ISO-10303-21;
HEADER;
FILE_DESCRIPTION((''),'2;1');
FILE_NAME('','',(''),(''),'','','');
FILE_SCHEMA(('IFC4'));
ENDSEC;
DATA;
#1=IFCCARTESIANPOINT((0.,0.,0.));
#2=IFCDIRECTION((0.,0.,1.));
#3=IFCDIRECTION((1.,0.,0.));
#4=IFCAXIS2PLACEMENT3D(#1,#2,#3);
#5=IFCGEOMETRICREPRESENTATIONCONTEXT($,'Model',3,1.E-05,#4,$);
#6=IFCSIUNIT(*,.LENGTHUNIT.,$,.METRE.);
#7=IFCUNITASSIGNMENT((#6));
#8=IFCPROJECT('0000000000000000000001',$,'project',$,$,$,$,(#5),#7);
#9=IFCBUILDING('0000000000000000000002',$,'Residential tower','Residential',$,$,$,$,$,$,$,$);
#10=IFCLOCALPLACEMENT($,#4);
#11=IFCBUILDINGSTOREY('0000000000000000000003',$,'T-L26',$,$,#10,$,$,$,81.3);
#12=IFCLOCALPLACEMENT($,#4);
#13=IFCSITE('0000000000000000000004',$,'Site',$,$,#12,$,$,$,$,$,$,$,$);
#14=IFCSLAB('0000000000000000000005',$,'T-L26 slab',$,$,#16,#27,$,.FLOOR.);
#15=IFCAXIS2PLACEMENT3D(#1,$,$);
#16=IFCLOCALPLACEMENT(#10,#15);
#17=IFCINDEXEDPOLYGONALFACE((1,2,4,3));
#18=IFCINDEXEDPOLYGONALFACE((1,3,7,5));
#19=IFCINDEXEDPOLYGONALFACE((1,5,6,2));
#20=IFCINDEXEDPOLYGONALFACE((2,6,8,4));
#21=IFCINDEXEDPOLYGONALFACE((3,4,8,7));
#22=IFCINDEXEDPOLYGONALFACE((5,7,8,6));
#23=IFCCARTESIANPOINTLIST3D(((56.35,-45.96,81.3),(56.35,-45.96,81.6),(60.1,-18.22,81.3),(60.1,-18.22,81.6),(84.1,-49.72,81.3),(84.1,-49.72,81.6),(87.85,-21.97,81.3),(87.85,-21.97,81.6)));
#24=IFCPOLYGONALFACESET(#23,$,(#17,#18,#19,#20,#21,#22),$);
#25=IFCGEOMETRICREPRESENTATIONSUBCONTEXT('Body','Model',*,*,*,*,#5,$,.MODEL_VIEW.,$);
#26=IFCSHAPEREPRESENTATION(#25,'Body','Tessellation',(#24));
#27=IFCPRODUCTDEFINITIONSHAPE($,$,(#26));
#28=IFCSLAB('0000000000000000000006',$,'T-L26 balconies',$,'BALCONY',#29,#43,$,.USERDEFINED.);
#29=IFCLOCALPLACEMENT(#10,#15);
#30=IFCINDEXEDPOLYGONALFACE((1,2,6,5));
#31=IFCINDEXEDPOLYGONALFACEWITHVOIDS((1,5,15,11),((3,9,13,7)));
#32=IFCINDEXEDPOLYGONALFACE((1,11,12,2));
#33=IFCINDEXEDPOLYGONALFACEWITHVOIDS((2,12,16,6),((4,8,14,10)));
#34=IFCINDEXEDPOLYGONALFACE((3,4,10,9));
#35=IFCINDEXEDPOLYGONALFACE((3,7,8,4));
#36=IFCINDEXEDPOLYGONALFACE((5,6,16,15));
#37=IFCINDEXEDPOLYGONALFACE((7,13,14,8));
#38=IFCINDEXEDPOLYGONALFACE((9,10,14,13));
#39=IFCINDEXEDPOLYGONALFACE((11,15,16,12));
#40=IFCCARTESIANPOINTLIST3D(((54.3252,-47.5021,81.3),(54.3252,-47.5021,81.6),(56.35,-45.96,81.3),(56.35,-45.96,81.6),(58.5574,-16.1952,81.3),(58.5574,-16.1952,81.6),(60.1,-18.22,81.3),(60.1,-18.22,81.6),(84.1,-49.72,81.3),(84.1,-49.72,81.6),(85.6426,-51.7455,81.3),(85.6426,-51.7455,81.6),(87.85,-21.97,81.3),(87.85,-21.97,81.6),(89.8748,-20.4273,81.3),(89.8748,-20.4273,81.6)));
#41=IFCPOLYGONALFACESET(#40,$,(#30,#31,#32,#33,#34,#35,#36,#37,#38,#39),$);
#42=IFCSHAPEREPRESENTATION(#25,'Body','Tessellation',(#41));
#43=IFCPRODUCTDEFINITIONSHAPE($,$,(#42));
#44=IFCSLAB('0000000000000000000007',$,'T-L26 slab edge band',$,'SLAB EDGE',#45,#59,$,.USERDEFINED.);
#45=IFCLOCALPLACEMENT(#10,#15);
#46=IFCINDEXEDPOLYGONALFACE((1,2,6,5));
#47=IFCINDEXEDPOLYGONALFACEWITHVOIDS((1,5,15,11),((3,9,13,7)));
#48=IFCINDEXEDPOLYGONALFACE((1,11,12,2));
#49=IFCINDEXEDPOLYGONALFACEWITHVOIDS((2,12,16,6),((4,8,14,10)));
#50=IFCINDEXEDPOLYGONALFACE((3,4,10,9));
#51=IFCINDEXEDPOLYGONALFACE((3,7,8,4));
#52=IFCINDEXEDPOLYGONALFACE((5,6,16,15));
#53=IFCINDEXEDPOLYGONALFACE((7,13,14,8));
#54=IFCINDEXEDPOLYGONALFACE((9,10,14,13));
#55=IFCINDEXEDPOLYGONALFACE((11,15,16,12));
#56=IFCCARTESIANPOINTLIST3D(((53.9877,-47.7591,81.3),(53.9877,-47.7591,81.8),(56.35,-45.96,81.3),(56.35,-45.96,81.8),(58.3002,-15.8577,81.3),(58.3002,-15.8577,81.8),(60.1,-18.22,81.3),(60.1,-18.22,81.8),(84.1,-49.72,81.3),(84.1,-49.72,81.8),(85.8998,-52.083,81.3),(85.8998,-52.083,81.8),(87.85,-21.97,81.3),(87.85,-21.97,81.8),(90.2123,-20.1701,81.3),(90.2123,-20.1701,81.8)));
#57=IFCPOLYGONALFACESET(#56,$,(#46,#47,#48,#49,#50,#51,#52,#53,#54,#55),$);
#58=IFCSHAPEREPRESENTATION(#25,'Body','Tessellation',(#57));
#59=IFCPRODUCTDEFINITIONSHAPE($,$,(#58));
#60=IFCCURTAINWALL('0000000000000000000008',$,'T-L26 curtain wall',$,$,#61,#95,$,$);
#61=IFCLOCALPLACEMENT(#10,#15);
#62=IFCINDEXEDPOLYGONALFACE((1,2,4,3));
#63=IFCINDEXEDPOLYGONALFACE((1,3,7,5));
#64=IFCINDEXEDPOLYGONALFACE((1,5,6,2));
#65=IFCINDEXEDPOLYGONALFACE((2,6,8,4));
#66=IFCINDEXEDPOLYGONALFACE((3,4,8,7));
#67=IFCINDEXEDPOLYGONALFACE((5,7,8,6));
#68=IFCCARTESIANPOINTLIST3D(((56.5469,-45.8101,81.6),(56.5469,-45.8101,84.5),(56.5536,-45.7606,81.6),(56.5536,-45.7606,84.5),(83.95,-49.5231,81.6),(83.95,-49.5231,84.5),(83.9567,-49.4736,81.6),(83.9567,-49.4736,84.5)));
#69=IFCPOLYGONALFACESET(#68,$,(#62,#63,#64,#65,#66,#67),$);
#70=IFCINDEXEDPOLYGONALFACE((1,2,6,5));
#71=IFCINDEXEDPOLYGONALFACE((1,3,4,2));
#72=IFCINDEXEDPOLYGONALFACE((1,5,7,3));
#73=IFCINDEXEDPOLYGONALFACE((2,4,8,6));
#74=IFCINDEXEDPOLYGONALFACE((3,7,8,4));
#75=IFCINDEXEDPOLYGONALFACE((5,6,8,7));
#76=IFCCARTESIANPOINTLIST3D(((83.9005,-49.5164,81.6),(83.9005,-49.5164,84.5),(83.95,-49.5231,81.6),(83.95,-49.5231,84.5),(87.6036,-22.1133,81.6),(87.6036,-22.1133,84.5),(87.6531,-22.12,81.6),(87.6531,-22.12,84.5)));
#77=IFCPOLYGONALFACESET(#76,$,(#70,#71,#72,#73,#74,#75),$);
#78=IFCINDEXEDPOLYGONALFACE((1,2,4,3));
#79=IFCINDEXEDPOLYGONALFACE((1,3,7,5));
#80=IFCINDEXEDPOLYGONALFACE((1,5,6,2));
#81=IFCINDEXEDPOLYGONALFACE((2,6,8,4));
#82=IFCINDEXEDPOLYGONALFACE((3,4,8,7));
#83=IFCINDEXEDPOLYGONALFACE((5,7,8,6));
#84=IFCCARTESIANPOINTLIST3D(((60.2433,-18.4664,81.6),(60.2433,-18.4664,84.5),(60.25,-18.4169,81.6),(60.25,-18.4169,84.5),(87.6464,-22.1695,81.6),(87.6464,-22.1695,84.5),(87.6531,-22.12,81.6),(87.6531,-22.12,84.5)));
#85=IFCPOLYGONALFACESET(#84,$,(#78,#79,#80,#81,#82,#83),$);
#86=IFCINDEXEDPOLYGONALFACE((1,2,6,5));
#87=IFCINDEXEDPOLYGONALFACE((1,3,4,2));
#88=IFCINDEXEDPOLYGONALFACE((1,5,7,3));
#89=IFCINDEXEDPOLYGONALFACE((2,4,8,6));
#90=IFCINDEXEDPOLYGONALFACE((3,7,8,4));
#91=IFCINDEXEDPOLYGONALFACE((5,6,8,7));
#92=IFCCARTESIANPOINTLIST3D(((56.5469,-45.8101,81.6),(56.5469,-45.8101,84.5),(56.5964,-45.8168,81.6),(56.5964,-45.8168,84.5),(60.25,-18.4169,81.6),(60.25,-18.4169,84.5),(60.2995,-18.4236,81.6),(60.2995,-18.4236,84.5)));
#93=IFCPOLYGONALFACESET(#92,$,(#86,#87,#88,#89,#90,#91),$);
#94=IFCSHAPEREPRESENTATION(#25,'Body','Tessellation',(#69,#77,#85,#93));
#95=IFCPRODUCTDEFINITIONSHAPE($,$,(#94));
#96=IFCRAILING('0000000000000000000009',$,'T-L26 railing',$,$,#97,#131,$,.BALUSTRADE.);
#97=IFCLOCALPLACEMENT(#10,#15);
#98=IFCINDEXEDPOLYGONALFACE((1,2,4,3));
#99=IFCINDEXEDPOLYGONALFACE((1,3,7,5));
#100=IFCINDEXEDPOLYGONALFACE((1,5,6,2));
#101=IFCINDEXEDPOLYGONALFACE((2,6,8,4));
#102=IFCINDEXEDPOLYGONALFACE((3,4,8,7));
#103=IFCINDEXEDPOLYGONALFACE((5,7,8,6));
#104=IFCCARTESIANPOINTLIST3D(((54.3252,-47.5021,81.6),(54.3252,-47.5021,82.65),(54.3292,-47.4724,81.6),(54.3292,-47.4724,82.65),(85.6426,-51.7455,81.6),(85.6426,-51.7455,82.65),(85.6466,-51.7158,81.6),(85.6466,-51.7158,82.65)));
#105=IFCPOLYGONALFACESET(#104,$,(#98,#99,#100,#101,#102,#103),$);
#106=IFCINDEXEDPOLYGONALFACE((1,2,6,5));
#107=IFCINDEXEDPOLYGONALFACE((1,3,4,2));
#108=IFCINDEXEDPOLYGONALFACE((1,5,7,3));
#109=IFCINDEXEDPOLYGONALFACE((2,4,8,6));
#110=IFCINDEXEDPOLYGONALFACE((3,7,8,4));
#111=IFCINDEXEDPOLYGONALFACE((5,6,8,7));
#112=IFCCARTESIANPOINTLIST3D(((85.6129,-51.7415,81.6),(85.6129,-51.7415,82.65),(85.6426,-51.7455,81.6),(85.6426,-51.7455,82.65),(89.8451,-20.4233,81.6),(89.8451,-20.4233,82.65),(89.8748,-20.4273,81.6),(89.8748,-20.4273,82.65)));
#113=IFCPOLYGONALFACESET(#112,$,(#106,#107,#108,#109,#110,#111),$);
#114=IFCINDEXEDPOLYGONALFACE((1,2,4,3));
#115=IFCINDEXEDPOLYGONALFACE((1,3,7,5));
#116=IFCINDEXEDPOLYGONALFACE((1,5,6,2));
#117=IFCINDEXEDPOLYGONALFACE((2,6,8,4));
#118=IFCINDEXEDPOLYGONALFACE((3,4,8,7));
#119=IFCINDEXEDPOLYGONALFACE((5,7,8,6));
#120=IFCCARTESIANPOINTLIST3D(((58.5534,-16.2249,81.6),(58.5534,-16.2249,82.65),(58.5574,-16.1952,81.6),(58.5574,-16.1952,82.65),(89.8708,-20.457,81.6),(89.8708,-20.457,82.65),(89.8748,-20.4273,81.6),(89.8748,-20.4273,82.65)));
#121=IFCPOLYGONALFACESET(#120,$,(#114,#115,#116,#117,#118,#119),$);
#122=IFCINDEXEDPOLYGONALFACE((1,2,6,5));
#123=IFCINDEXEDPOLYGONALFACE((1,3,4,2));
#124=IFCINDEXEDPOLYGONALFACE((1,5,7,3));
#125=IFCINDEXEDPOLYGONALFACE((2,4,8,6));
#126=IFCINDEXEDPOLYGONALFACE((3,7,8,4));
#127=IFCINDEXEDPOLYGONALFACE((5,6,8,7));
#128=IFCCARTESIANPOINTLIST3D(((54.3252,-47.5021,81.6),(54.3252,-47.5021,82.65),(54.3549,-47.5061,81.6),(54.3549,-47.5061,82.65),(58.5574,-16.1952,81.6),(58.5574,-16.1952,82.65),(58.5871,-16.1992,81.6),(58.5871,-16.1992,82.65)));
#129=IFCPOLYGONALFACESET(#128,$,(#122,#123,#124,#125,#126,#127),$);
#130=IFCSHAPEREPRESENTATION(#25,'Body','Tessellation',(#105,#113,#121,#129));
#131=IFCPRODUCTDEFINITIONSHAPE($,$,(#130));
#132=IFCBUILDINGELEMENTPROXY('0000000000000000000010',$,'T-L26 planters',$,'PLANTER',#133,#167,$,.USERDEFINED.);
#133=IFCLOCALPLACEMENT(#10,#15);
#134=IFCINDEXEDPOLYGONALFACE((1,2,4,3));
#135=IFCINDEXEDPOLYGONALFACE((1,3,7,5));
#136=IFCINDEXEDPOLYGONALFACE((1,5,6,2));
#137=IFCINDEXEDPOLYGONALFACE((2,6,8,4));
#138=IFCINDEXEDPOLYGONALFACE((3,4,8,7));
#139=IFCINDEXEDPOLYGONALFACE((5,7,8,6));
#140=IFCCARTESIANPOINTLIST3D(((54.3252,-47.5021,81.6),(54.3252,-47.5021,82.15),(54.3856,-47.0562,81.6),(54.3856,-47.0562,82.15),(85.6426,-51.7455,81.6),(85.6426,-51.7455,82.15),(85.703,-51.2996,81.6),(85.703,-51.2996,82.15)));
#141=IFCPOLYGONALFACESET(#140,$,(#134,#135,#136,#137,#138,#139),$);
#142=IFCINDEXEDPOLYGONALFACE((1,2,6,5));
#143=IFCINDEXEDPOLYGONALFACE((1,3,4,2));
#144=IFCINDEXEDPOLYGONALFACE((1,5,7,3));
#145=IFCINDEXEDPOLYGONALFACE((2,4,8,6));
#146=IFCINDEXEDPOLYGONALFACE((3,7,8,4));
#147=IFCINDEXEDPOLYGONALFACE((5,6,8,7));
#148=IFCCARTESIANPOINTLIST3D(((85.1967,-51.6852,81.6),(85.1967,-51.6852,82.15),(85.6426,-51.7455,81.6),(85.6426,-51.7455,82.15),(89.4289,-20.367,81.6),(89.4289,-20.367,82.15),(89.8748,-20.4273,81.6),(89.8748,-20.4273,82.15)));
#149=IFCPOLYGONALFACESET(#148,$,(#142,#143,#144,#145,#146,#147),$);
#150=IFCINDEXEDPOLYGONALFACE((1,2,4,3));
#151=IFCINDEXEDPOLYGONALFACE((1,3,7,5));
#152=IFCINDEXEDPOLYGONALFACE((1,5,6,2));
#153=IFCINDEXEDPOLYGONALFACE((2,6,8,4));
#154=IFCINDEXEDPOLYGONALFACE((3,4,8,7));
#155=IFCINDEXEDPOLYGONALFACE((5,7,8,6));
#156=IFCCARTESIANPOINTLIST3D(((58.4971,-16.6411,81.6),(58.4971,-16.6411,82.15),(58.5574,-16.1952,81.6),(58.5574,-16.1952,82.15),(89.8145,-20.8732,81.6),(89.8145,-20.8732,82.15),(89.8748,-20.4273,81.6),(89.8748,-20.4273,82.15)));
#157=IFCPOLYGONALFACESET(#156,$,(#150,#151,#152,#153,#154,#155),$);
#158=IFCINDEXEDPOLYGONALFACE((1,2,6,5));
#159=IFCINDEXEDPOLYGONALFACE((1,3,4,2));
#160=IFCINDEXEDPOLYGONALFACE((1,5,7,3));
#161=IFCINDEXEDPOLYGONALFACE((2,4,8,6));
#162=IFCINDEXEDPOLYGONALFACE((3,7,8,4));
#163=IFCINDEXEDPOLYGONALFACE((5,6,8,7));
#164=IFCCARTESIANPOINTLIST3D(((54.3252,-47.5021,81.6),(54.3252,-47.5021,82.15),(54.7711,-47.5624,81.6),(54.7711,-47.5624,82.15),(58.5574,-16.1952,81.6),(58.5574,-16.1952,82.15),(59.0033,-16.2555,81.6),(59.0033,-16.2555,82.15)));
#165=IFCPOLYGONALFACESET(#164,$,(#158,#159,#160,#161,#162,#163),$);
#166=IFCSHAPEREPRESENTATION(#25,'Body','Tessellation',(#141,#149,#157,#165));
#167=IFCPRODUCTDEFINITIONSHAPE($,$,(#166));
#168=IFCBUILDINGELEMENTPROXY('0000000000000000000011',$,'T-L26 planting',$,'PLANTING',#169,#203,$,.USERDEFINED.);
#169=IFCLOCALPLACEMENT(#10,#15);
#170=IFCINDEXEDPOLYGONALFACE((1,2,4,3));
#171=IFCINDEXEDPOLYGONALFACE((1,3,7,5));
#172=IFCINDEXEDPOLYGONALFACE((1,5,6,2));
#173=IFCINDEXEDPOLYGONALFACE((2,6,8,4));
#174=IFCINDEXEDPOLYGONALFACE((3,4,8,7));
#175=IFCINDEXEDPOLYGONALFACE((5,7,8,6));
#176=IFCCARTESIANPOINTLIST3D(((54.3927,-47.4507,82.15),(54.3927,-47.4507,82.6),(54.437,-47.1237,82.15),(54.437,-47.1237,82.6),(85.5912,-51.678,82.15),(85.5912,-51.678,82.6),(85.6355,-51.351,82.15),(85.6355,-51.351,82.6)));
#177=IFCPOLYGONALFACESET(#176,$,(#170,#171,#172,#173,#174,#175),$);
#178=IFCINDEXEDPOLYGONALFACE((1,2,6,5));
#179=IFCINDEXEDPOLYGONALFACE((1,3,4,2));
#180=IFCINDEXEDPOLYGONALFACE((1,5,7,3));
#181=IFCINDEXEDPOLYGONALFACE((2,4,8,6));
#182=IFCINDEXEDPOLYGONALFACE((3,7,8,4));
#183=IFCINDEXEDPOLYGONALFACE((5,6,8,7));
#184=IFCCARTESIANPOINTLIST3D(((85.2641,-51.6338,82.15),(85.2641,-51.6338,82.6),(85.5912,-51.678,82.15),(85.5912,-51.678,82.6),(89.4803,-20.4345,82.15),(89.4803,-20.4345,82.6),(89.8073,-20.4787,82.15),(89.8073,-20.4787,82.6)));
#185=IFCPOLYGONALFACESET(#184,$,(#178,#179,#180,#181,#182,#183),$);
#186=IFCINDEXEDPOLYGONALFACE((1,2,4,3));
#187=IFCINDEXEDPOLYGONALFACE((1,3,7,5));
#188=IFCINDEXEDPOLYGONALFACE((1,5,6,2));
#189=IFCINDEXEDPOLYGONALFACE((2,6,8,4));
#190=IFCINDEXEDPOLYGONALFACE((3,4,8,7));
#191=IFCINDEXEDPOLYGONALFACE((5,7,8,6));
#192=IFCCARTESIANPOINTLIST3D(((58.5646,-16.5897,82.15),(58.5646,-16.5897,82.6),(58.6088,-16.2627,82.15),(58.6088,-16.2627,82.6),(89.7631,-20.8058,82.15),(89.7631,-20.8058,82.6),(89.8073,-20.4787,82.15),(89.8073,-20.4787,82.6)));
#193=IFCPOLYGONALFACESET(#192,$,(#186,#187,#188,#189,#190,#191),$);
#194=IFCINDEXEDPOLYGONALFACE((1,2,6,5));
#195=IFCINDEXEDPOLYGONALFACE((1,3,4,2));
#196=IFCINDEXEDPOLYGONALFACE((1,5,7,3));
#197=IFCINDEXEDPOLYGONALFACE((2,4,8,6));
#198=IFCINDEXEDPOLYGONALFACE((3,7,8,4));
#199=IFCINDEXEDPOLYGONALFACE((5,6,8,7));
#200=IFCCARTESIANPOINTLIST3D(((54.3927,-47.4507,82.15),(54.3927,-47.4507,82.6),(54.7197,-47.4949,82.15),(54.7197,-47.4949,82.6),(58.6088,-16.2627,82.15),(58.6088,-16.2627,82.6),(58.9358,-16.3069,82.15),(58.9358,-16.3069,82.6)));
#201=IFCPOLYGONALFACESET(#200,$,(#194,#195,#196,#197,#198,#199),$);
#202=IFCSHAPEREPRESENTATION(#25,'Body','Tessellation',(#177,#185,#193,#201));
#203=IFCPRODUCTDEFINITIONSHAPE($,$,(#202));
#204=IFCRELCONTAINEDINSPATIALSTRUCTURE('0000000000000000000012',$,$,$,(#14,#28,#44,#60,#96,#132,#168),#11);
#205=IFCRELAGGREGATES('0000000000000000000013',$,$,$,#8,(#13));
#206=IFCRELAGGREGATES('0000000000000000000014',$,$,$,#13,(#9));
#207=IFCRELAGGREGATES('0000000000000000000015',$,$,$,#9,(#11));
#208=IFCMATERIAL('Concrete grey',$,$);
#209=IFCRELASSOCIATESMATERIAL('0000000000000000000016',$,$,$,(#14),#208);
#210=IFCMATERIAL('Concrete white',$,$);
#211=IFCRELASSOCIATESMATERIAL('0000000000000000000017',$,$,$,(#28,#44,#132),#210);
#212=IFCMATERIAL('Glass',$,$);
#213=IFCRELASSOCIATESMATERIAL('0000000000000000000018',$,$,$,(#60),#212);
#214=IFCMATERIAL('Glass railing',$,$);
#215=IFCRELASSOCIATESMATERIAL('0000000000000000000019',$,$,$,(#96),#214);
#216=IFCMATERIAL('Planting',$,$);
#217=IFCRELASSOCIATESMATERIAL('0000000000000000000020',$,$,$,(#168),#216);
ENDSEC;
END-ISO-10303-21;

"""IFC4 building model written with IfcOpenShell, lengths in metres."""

from ifc_helpers import new_model, si_unit, frame, origin_with_axes, place, context, subcontext, project, spatial, polyline, outline, extrude, material, element, save


model = new_model("IFC4")

# Units and contexts
model_context = context("Model", 3, precision=1e-05, world=origin_with_axes())
body_context = subcontext(model_context, "Body", "Model", "MODEL_VIEW")
ifc_project = project(units=[si_unit("LENGTHUNIT", "METRE")], contexts=[model_context])

# Site, building, storey
site_placement = place(None, origin_with_axes())
site = spatial("IfcSite", under=ifc_project, at=site_placement, Name="Site")
building = spatial("IfcBuilding", under=site, Name="Residential tower", Description="Residential")
storey_placement = place(None, origin_with_axes())
storey = spatial("IfcBuildingStorey", under=building, at=storey_placement, Name="T-L26", Elevation=81.3)

# Slabs
ifc_material_1 = material(Name="Concrete grey")
slab_1_placement = place(storey_placement, origin_with_axes())
element("IfcSlab", 1, at=slab_1_placement, inside=storey, material=ifc_material_1, Name="T-L26 slab", PredefinedType="FLOOR", context=body_context, shape_type="SweptSolid", body=[
    extrude(outline(polyline([(56.35, -45.96), (84.1, -49.72), (87.85, -21.97), (60.1, -18.22), (56.35, -45.96)])), frame((0.0, 0.0, 81.3), z_axis=(0.0, 0.0, 1.0), x_axis=(1.0, 0.0, 0.0)), (0.0, 0.0, 1.0), 0.3),
])
ifc_material_2 = material(Name="Concrete white")
slab_2_placement = place(storey_placement, origin_with_axes())
element("IfcSlab", 2, at=slab_2_placement, inside=storey, material=ifc_material_2, Name="T-L26 balconies", ObjectType="BALCONY", PredefinedType="USERDEFINED", context=body_context, shape_type="SweptSolid", body=[
    extrude(outline(polyline([(54.3252, -47.5021), (85.6426, -51.7455), (89.8748, -20.4273), (58.5574, -16.1952), (54.3252, -47.5021)]), holes=[polyline([(56.35, -45.96), (84.1, -49.72), (87.85, -21.97), (60.1, -18.22), (56.35, -45.96)])]), frame((0.0, 0.0, 81.3), z_axis=(0.0, 0.0, 1.0), x_axis=(1.0, 0.0, 0.0)), (0.0, 0.0, 1.0), 0.3),
])
slab_3_placement = place(storey_placement, origin_with_axes())
element("IfcSlab", 3, at=slab_3_placement, inside=storey, material=ifc_material_2, Name="T-L26 slab edge band", ObjectType="SLAB EDGE", PredefinedType="USERDEFINED", context=body_context, shape_type="SweptSolid", body=[
    extrude(outline(polyline([(53.9877, -47.7591), (85.8998, -52.083), (90.2123, -20.1701), (58.3002, -15.8577), (53.9877, -47.7591)]), holes=[polyline([(56.35, -45.96), (84.1, -49.72), (87.85, -21.97), (60.1, -18.22), (56.35, -45.96)])]), frame((0.0, 0.0, 81.3), z_axis=(0.0, 0.0, 1.0), x_axis=(1.0, 0.0, 0.0)), (0.0, 0.0, 1.0), 0.5),
])

# Curtain wall
ifc_material_3 = material(Name="Glass")
curtain_wall_placement = place(storey_placement, origin_with_axes())
element("IfcCurtainWall", 4, at=curtain_wall_placement, inside=storey, material=ifc_material_3, Name="T-L26 curtain wall", context=body_context, shape_type="SweptSolid", body=[
    extrude(outline(polyline([(56.5469, -45.8101), (83.95, -49.5231), (83.9567, -49.4736), (56.5536, -45.7606), (56.5469, -45.8101)])), frame((0.0, 0.0, 81.6), z_axis=(0.0, 0.0, 1.0), x_axis=(1.0, 0.0, 0.0)), (0.0, 0.0, 1.0), 2.9),
    extrude(outline(polyline([(83.95, -49.5231), (87.6531, -22.12), (87.6036, -22.1133), (83.9005, -49.5164), (83.95, -49.5231)])), frame((0.0, 0.0, 81.6), z_axis=(0.0, 0.0, 1.0), x_axis=(1.0, 0.0, 0.0)), (0.0, 0.0, 1.0), 2.9),
    extrude(outline(polyline([(87.6531, -22.12), (60.25, -18.4169), (60.2433, -18.4664), (87.6464, -22.1695), (87.6531, -22.12)])), frame((0.0, 0.0, 81.6), z_axis=(0.0, 0.0, 1.0), x_axis=(1.0, 0.0, 0.0)), (0.0, 0.0, 1.0), 2.9),
    extrude(outline(polyline([(60.25, -18.4169), (56.5469, -45.8101), (56.5964, -45.8168), (60.2995, -18.4236), (60.25, -18.4169)])), frame((0.0, 0.0, 81.6), z_axis=(0.0, 0.0, 1.0), x_axis=(1.0, 0.0, 0.0)), (0.0, 0.0, 1.0), 2.9),
])

# Railing
ifc_material_4 = material(Name="Glass railing")
railing_placement = place(storey_placement, origin_with_axes())
element("IfcRailing", 5, at=railing_placement, inside=storey, material=ifc_material_4, Name="T-L26 railing", PredefinedType="BALUSTRADE", context=body_context, shape_type="SweptSolid", body=[
    extrude(outline(polyline([(54.3252, -47.5021), (85.6426, -51.7455), (85.6466, -51.7158), (54.3292, -47.4724), (54.3252, -47.5021)])), frame((0.0, 0.0, 81.6), z_axis=(0.0, 0.0, 1.0), x_axis=(1.0, 0.0, 0.0)), (0.0, 0.0, 1.0), 1.05),
    extrude(outline(polyline([(85.6426, -51.7455), (89.8748, -20.4273), (89.8451, -20.4233), (85.6129, -51.7415), (85.6426, -51.7455)])), frame((0.0, 0.0, 81.6), z_axis=(0.0, 0.0, 1.0), x_axis=(1.0, 0.0, 0.0)), (0.0, 0.0, 1.0), 1.05),
    extrude(outline(polyline([(89.8748, -20.4273), (58.5574, -16.1952), (58.5534, -16.2249), (89.8708, -20.457), (89.8748, -20.4273)])), frame((0.0, 0.0, 81.6), z_axis=(0.0, 0.0, 1.0), x_axis=(1.0, 0.0, 0.0)), (0.0, 0.0, 1.0), 1.05),
    extrude(outline(polyline([(58.5574, -16.1952), (54.3252, -47.5021), (54.3549, -47.5061), (58.5871, -16.1992), (58.5574, -16.1952)])), frame((0.0, 0.0, 81.6), z_axis=(0.0, 0.0, 1.0), x_axis=(1.0, 0.0, 0.0)), (0.0, 0.0, 1.0), 1.05),
])

# Building element proxies
proxy_1_placement = place(storey_placement, origin_with_axes())
element("IfcBuildingElementProxy", 6, at=proxy_1_placement, inside=storey, material=ifc_material_2, Name="T-L26 planters", ObjectType="PLANTER", PredefinedType="USERDEFINED", context=body_context, shape_type="SweptSolid", body=[
    extrude(outline(polyline([(54.3252, -47.5021), (85.6426, -51.7455), (85.703, -51.2996), (54.3856, -47.0562), (54.3252, -47.5021)])), frame((0.0, 0.0, 81.6), z_axis=(0.0, 0.0, 1.0), x_axis=(1.0, 0.0, 0.0)), (0.0, 0.0, 1.0), 0.55),
    extrude(outline(polyline([(85.6426, -51.7455), (89.8748, -20.4273), (89.4289, -20.367), (85.1967, -51.6852), (85.6426, -51.7455)])), frame((0.0, 0.0, 81.6), z_axis=(0.0, 0.0, 1.0), x_axis=(1.0, 0.0, 0.0)), (0.0, 0.0, 1.0), 0.55),
    extrude(outline(polyline([(89.8748, -20.4273), (58.5574, -16.1952), (58.4971, -16.6411), (89.8145, -20.8732), (89.8748, -20.4273)])), frame((0.0, 0.0, 81.6), z_axis=(0.0, 0.0, 1.0), x_axis=(1.0, 0.0, 0.0)), (0.0, 0.0, 1.0), 0.55),
    extrude(outline(polyline([(58.5574, -16.1952), (54.3252, -47.5021), (54.7711, -47.5624), (59.0033, -16.2555), (58.5574, -16.1952)])), frame((0.0, 0.0, 81.6), z_axis=(0.0, 0.0, 1.0), x_axis=(1.0, 0.0, 0.0)), (0.0, 0.0, 1.0), 0.55),
])
ifc_material_5 = material(Name="Planting")
proxy_2_placement = place(storey_placement, origin_with_axes())
element("IfcBuildingElementProxy", 7, at=proxy_2_placement, inside=storey, material=ifc_material_5, Name="T-L26 planting", ObjectType="PLANTING", PredefinedType="USERDEFINED", context=body_context, shape_type="SweptSolid", body=[
    extrude(outline(polyline([(54.3927, -47.4507), (85.5912, -51.678), (85.6355, -51.351), (54.437, -47.1237), (54.3927, -47.4507)])), frame((0.0, 0.0, 82.15), z_axis=(0.0, 0.0, 1.0), x_axis=(1.0, 0.0, 0.0)), (0.0, 0.0, 1.0), 0.45),
    extrude(outline(polyline([(85.5912, -51.678), (89.8073, -20.4787), (89.4803, -20.4345), (85.2641, -51.6338), (85.5912, -51.678)])), frame((0.0, 0.0, 82.15), z_axis=(0.0, 0.0, 1.0), x_axis=(1.0, 0.0, 0.0)), (0.0, 0.0, 1.0), 0.45),
    extrude(outline(polyline([(89.8073, -20.4787), (58.6088, -16.2627), (58.5646, -16.5897), (89.7631, -20.8058), (89.8073, -20.4787)])), frame((0.0, 0.0, 82.15), z_axis=(0.0, 0.0, 1.0), x_axis=(1.0, 0.0, 0.0)), (0.0, 0.0, 1.0), 0.45),
    extrude(outline(polyline([(58.6088, -16.2627), (54.3927, -47.4507), (54.7197, -47.4949), (58.9358, -16.3069), (58.6088, -16.2627)])), frame((0.0, 0.0, 82.15), z_axis=(0.0, 0.0, 1.0), x_axis=(1.0, 0.0, 0.0)), (0.0, 0.0, 1.0), 0.45),
])

save(model, "model.ifc")
